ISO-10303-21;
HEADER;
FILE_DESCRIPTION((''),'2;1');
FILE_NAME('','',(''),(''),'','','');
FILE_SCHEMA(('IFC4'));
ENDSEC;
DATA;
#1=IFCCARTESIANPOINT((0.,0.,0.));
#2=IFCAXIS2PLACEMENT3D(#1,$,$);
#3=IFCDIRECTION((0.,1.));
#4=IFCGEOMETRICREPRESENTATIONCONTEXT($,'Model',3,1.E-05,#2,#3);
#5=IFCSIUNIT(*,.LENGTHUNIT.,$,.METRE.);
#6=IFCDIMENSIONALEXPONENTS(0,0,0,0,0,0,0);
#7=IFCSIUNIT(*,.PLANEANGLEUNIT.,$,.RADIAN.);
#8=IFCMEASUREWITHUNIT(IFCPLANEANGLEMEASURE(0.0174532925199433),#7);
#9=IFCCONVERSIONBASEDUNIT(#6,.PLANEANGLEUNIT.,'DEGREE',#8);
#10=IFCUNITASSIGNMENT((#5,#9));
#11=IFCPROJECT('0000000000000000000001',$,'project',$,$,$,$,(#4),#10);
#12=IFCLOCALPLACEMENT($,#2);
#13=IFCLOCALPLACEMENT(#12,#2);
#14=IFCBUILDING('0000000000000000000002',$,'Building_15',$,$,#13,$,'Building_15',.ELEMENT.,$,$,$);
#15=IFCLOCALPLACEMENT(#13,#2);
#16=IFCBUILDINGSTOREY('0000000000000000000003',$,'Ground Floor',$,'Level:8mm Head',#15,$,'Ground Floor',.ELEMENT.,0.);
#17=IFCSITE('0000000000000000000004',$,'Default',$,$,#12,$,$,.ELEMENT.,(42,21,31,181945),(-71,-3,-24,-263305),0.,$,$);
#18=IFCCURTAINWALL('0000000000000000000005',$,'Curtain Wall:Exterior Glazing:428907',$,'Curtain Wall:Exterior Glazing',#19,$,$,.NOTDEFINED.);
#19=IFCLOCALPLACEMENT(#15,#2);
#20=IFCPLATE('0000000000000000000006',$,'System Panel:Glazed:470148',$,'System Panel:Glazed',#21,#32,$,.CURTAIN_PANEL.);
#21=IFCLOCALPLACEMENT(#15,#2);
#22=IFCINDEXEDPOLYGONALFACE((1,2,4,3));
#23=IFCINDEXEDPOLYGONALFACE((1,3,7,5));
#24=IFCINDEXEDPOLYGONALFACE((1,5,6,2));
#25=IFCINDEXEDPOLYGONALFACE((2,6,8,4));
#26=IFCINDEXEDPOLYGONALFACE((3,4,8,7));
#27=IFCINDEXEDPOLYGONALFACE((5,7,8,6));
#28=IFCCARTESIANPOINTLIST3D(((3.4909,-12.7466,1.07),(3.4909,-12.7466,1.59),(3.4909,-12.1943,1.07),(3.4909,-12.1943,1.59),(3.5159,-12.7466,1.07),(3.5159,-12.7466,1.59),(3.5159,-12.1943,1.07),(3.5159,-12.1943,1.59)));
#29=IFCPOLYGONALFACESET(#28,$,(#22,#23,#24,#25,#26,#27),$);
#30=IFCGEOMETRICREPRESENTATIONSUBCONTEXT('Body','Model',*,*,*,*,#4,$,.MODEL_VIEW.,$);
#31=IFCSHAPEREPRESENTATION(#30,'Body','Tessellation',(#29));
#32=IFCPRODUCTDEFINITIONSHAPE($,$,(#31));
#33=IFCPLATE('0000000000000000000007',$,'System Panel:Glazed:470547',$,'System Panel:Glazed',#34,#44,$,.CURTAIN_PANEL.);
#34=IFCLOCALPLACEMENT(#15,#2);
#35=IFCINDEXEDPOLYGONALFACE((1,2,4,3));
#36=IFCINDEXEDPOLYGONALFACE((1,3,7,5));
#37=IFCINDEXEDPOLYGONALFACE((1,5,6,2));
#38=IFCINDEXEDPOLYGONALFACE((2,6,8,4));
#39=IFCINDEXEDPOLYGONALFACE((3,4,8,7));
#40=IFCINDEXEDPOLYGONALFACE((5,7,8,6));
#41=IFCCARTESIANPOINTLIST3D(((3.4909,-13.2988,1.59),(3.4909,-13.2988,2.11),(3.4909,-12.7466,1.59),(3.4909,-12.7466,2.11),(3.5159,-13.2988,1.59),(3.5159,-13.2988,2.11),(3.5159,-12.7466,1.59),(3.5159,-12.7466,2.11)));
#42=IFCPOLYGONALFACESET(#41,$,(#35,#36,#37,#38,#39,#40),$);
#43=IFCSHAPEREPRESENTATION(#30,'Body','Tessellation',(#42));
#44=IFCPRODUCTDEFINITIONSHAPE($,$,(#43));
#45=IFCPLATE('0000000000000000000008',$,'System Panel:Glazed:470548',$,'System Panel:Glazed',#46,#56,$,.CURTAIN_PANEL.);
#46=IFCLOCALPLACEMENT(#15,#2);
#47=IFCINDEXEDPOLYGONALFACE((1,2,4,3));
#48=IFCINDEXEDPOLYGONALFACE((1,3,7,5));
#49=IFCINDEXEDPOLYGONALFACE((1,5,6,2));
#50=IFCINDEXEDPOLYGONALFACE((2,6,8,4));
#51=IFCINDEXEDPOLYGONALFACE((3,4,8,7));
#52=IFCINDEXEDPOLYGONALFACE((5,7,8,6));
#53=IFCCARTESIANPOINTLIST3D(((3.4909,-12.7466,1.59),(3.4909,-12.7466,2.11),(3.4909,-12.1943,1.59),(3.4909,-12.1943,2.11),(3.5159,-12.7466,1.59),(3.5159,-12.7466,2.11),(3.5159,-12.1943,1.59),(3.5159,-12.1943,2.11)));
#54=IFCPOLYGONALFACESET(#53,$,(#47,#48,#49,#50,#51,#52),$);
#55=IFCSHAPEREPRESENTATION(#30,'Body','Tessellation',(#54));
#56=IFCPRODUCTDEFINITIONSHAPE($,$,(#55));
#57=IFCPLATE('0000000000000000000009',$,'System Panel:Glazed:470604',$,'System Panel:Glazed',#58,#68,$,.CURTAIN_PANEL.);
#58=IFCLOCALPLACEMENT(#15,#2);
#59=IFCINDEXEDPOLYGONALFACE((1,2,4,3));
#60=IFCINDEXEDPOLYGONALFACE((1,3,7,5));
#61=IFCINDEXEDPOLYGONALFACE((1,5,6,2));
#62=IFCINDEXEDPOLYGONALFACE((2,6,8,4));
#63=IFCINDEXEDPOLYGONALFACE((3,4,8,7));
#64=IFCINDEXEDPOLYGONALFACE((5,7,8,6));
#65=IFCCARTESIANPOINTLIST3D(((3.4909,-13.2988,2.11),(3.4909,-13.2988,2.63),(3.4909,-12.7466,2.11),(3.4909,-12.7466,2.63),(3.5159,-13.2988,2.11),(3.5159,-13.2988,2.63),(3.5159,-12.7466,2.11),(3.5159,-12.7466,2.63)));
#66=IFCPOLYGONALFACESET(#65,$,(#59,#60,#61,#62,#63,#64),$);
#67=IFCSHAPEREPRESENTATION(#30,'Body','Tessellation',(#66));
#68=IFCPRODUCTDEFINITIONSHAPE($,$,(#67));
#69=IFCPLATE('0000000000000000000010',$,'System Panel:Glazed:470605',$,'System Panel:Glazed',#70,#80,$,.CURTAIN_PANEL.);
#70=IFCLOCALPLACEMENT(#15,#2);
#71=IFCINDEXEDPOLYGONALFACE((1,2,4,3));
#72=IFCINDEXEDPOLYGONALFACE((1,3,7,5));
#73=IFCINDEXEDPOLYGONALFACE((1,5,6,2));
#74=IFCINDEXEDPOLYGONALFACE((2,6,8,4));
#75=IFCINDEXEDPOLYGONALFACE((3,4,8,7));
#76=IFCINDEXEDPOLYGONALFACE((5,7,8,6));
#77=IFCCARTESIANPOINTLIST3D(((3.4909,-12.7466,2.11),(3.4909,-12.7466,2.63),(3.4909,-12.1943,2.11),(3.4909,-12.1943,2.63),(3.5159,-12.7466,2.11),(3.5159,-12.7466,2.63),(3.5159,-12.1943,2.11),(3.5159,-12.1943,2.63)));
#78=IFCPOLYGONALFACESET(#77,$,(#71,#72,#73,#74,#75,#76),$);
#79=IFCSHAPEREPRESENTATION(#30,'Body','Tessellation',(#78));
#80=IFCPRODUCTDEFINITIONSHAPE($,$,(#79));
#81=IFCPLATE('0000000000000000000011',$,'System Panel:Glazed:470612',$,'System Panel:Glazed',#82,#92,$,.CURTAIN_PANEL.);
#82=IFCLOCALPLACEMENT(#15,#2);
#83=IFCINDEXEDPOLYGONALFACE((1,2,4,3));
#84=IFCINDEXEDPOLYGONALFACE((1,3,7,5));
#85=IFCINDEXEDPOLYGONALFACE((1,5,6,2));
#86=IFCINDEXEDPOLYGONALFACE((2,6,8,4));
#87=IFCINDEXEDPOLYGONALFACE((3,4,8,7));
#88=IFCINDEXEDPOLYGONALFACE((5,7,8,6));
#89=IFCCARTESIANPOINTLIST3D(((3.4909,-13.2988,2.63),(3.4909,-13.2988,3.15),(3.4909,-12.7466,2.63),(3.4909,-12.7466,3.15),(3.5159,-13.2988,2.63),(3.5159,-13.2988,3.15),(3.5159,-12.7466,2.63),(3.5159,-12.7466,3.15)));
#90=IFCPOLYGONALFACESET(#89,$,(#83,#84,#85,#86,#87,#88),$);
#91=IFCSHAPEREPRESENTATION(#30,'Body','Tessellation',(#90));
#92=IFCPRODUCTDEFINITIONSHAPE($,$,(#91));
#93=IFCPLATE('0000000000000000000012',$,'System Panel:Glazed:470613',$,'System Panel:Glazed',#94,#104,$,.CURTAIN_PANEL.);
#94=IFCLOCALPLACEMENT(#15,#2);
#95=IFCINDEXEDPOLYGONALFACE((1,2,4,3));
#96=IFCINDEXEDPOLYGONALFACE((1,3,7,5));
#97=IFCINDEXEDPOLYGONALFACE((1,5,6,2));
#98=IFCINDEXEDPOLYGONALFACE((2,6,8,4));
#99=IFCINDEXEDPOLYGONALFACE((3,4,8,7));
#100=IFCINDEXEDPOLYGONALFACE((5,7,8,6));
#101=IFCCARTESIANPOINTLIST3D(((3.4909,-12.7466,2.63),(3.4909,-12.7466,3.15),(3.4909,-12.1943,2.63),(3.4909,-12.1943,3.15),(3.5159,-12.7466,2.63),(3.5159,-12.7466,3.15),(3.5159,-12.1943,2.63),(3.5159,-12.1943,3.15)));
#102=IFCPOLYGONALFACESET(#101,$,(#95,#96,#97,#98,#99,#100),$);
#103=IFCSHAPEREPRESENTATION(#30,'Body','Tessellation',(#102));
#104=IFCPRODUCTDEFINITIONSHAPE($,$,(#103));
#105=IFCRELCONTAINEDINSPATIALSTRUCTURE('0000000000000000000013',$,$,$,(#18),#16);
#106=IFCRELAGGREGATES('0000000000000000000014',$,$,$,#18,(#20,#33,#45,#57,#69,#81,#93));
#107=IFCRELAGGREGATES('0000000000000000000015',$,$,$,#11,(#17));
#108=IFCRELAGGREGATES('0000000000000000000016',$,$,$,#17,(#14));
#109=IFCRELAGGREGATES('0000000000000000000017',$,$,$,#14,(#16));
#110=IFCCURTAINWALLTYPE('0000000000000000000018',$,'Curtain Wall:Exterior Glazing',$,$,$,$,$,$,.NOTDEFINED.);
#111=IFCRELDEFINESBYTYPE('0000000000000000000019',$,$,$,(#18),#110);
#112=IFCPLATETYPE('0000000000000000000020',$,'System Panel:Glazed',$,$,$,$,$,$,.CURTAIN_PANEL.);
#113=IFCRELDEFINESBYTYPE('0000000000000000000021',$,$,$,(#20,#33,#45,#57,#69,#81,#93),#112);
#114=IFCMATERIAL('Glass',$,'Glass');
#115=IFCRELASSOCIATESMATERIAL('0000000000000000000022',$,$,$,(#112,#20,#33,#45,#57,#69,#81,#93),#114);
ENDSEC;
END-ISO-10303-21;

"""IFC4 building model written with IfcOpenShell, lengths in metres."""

from ifc_helpers import new_model, entity, si_unit, converted_unit, direction, frame, origin, place, context, subcontext, project, spatial, indexed_curve, outline, extrude, source, transform, mapped, material, type_object, type_shapes, element, aggregate, save


model = new_model("IFC4")

# Units and contexts
model_context = context("Model", 3, precision=1e-05, world=origin(), true_north=direction((0.0, 1.0)))
body_context = subcontext(model_context, "Body", "Model", "MODEL_VIEW")
ifc_project = project(units=[si_unit("LENGTHUNIT", "METRE"), converted_unit("PLANEANGLEUNIT", "DEGREE", entity("IfcPlaneAngleMeasure", 0.0174532925199433), si_unit("PLANEANGLEUNIT", "RADIAN"), dimensions=[0, 0, 0, 0, 0, 0, 0])], contexts=[model_context])

# Site, building, storey
site_placement = place(None, origin())
site = spatial("IfcSite", under=ifc_project, at=site_placement, Name="Default", CompositionType="ELEMENT", RefLatitude=(42, 21, 31, 181945), RefLongitude=(-71, -3, -24, -263305), RefElevation=0.0)
building_placement = place(site_placement, origin())
building = spatial("IfcBuilding", under=site, at=building_placement, Name="Building_15", LongName="Building_15", CompositionType="ELEMENT")
storey_placement = place(building_placement, origin())
storey = spatial("IfcBuildingStorey", under=building, at=storey_placement, Name="Ground Floor", ObjectType="Level:8mm Head", LongName="Ground Floor", CompositionType="ELEMENT", Elevation=0.0)

# Curtain wall
curtain_wall_type = type_object("IfcCurtainWallType", Name="Curtain Wall:Exterior Glazing", PredefinedType="NOTDEFINED")
curtain_wall_1_placement = place(storey_placement, origin())
curtain_wall_1 = element("IfcCurtainWall", 1, at=curtain_wall_1_placement, inside=storey, type_object=curtain_wall_type, Name="Curtain Wall:Exterior Glazing:428907", ObjectType="Curtain Wall:Exterior Glazing", PredefinedType="NOTDEFINED")

# Shared definitions
ifc_material_1 = material(Name="Glass", Category="Glass")

# Plates
plate_type_1 = type_object("IfcPlateType", Name="System Panel:Glazed", PredefinedType="CURTAIN_PANEL", material=ifc_material_1)
shared_shape_1 = source(origin(), body_context, "Body", "SweptSolid", [
    extrude(outline(indexed_curve([(-0.0125, -0.2761), (0.0125, -0.2761), (0.0125, 0.2761), (-0.0125, 0.2761), (-0.0125, -0.2761)], self_intersect=False)), frame((0.0, 0.037, 0.0), z_axis=(0.0, 0.0, 1.0), x_axis=(0.0, 1.0, 0.0)), (0.0, 0.0, 1.0), 0.52),
])
type_shapes(plate_type_1, [shared_shape_1])
plate_1_placement = place(curtain_wall_1_placement, frame((3.5404, -12.4705, 1.07), z_axis=(0.0, 0.0, 1.0), x_axis=(0.0, 1.0, 0.0)))
plate_1 = element("IfcPlate", 2, at=plate_1_placement, type_object=plate_type_1, material=ifc_material_1, Name="System Panel:Glazed:470148", ObjectType="System Panel:Glazed", PredefinedType="CURTAIN_PANEL", context=body_context, shape_type="MappedRepresentation", body=[
    mapped(shared_shape_1, transform((0.0, 0.0, 0.0), scale=1.0)),
])
plate_2_placement = place(curtain_wall_1_placement, frame((3.5404, -13.0227, 1.59), z_axis=(0.0, 0.0, 1.0), x_axis=(0.0, 1.0, 0.0)))
plate_2 = element("IfcPlate", 3, at=plate_2_placement, type_object=plate_type_1, material=ifc_material_1, Name="System Panel:Glazed:470547", ObjectType="System Panel:Glazed", PredefinedType="CURTAIN_PANEL", context=body_context, shape_type="MappedRepresentation", body=[
    mapped(shared_shape_1, transform((0.0, 0.0, 0.0), scale=1.0)),
])
plate_3_placement = place(curtain_wall_1_placement, frame((3.5404, -12.4705, 1.59), z_axis=(0.0, 0.0, 1.0), x_axis=(0.0, 1.0, 0.0)))
plate_3 = element("IfcPlate", 4, at=plate_3_placement, type_object=plate_type_1, material=ifc_material_1, Name="System Panel:Glazed:470548", ObjectType="System Panel:Glazed", PredefinedType="CURTAIN_PANEL", context=body_context, shape_type="MappedRepresentation", body=[
    mapped(shared_shape_1, transform((0.0, 0.0, 0.0), scale=1.0)),
])
plate_4_placement = place(curtain_wall_1_placement, frame((3.5404, -13.0227, 2.11), z_axis=(0.0, 0.0, 1.0), x_axis=(0.0, 1.0, 0.0)))
plate_4 = element("IfcPlate", 5, at=plate_4_placement, type_object=plate_type_1, material=ifc_material_1, Name="System Panel:Glazed:470604", ObjectType="System Panel:Glazed", PredefinedType="CURTAIN_PANEL", context=body_context, shape_type="MappedRepresentation", body=[
    mapped(shared_shape_1, transform((0.0, 0.0, 0.0), scale=1.0)),
])
plate_5_placement = place(curtain_wall_1_placement, frame((3.5404, -12.4705, 2.11), z_axis=(0.0, 0.0, 1.0), x_axis=(0.0, 1.0, 0.0)))
plate_5 = element("IfcPlate", 6, at=plate_5_placement, type_object=plate_type_1, material=ifc_material_1, Name="System Panel:Glazed:470605", ObjectType="System Panel:Glazed", PredefinedType="CURTAIN_PANEL", context=body_context, shape_type="MappedRepresentation", body=[
    mapped(shared_shape_1, transform((0.0, 0.0, 0.0), scale=1.0)),
])
plate_6_placement = place(curtain_wall_1_placement, frame((3.5404, -13.0227, 2.63), z_axis=(0.0, 0.0, 1.0), x_axis=(0.0, 1.0, 0.0)))
plate_6 = element("IfcPlate", 7, at=plate_6_placement, type_object=plate_type_1, material=ifc_material_1, Name="System Panel:Glazed:470612", ObjectType="System Panel:Glazed", PredefinedType="CURTAIN_PANEL", context=body_context, shape_type="MappedRepresentation", body=[
    mapped(shared_shape_1, transform((0.0, 0.0, 0.0), scale=1.0)),
])
plate_7_placement = place(curtain_wall_1_placement, frame((3.5404, -12.4705, 2.63), z_axis=(0.0, 0.0, 1.0), x_axis=(0.0, 1.0, 0.0)))
plate_7 = element("IfcPlate", 8, at=plate_7_placement, type_object=plate_type_1, material=ifc_material_1, Name="System Panel:Glazed:470613", ObjectType="System Panel:Glazed", PredefinedType="CURTAIN_PANEL", context=body_context, shape_type="MappedRepresentation", body=[
    mapped(shared_shape_1, transform((0.0, 0.0, 0.0), scale=1.0)),
])
aggregate(curtain_wall_1, [plate_1, plate_2, plate_3, plate_4, plate_5, plate_6, plate_7])

save(model, "model.ifc")
